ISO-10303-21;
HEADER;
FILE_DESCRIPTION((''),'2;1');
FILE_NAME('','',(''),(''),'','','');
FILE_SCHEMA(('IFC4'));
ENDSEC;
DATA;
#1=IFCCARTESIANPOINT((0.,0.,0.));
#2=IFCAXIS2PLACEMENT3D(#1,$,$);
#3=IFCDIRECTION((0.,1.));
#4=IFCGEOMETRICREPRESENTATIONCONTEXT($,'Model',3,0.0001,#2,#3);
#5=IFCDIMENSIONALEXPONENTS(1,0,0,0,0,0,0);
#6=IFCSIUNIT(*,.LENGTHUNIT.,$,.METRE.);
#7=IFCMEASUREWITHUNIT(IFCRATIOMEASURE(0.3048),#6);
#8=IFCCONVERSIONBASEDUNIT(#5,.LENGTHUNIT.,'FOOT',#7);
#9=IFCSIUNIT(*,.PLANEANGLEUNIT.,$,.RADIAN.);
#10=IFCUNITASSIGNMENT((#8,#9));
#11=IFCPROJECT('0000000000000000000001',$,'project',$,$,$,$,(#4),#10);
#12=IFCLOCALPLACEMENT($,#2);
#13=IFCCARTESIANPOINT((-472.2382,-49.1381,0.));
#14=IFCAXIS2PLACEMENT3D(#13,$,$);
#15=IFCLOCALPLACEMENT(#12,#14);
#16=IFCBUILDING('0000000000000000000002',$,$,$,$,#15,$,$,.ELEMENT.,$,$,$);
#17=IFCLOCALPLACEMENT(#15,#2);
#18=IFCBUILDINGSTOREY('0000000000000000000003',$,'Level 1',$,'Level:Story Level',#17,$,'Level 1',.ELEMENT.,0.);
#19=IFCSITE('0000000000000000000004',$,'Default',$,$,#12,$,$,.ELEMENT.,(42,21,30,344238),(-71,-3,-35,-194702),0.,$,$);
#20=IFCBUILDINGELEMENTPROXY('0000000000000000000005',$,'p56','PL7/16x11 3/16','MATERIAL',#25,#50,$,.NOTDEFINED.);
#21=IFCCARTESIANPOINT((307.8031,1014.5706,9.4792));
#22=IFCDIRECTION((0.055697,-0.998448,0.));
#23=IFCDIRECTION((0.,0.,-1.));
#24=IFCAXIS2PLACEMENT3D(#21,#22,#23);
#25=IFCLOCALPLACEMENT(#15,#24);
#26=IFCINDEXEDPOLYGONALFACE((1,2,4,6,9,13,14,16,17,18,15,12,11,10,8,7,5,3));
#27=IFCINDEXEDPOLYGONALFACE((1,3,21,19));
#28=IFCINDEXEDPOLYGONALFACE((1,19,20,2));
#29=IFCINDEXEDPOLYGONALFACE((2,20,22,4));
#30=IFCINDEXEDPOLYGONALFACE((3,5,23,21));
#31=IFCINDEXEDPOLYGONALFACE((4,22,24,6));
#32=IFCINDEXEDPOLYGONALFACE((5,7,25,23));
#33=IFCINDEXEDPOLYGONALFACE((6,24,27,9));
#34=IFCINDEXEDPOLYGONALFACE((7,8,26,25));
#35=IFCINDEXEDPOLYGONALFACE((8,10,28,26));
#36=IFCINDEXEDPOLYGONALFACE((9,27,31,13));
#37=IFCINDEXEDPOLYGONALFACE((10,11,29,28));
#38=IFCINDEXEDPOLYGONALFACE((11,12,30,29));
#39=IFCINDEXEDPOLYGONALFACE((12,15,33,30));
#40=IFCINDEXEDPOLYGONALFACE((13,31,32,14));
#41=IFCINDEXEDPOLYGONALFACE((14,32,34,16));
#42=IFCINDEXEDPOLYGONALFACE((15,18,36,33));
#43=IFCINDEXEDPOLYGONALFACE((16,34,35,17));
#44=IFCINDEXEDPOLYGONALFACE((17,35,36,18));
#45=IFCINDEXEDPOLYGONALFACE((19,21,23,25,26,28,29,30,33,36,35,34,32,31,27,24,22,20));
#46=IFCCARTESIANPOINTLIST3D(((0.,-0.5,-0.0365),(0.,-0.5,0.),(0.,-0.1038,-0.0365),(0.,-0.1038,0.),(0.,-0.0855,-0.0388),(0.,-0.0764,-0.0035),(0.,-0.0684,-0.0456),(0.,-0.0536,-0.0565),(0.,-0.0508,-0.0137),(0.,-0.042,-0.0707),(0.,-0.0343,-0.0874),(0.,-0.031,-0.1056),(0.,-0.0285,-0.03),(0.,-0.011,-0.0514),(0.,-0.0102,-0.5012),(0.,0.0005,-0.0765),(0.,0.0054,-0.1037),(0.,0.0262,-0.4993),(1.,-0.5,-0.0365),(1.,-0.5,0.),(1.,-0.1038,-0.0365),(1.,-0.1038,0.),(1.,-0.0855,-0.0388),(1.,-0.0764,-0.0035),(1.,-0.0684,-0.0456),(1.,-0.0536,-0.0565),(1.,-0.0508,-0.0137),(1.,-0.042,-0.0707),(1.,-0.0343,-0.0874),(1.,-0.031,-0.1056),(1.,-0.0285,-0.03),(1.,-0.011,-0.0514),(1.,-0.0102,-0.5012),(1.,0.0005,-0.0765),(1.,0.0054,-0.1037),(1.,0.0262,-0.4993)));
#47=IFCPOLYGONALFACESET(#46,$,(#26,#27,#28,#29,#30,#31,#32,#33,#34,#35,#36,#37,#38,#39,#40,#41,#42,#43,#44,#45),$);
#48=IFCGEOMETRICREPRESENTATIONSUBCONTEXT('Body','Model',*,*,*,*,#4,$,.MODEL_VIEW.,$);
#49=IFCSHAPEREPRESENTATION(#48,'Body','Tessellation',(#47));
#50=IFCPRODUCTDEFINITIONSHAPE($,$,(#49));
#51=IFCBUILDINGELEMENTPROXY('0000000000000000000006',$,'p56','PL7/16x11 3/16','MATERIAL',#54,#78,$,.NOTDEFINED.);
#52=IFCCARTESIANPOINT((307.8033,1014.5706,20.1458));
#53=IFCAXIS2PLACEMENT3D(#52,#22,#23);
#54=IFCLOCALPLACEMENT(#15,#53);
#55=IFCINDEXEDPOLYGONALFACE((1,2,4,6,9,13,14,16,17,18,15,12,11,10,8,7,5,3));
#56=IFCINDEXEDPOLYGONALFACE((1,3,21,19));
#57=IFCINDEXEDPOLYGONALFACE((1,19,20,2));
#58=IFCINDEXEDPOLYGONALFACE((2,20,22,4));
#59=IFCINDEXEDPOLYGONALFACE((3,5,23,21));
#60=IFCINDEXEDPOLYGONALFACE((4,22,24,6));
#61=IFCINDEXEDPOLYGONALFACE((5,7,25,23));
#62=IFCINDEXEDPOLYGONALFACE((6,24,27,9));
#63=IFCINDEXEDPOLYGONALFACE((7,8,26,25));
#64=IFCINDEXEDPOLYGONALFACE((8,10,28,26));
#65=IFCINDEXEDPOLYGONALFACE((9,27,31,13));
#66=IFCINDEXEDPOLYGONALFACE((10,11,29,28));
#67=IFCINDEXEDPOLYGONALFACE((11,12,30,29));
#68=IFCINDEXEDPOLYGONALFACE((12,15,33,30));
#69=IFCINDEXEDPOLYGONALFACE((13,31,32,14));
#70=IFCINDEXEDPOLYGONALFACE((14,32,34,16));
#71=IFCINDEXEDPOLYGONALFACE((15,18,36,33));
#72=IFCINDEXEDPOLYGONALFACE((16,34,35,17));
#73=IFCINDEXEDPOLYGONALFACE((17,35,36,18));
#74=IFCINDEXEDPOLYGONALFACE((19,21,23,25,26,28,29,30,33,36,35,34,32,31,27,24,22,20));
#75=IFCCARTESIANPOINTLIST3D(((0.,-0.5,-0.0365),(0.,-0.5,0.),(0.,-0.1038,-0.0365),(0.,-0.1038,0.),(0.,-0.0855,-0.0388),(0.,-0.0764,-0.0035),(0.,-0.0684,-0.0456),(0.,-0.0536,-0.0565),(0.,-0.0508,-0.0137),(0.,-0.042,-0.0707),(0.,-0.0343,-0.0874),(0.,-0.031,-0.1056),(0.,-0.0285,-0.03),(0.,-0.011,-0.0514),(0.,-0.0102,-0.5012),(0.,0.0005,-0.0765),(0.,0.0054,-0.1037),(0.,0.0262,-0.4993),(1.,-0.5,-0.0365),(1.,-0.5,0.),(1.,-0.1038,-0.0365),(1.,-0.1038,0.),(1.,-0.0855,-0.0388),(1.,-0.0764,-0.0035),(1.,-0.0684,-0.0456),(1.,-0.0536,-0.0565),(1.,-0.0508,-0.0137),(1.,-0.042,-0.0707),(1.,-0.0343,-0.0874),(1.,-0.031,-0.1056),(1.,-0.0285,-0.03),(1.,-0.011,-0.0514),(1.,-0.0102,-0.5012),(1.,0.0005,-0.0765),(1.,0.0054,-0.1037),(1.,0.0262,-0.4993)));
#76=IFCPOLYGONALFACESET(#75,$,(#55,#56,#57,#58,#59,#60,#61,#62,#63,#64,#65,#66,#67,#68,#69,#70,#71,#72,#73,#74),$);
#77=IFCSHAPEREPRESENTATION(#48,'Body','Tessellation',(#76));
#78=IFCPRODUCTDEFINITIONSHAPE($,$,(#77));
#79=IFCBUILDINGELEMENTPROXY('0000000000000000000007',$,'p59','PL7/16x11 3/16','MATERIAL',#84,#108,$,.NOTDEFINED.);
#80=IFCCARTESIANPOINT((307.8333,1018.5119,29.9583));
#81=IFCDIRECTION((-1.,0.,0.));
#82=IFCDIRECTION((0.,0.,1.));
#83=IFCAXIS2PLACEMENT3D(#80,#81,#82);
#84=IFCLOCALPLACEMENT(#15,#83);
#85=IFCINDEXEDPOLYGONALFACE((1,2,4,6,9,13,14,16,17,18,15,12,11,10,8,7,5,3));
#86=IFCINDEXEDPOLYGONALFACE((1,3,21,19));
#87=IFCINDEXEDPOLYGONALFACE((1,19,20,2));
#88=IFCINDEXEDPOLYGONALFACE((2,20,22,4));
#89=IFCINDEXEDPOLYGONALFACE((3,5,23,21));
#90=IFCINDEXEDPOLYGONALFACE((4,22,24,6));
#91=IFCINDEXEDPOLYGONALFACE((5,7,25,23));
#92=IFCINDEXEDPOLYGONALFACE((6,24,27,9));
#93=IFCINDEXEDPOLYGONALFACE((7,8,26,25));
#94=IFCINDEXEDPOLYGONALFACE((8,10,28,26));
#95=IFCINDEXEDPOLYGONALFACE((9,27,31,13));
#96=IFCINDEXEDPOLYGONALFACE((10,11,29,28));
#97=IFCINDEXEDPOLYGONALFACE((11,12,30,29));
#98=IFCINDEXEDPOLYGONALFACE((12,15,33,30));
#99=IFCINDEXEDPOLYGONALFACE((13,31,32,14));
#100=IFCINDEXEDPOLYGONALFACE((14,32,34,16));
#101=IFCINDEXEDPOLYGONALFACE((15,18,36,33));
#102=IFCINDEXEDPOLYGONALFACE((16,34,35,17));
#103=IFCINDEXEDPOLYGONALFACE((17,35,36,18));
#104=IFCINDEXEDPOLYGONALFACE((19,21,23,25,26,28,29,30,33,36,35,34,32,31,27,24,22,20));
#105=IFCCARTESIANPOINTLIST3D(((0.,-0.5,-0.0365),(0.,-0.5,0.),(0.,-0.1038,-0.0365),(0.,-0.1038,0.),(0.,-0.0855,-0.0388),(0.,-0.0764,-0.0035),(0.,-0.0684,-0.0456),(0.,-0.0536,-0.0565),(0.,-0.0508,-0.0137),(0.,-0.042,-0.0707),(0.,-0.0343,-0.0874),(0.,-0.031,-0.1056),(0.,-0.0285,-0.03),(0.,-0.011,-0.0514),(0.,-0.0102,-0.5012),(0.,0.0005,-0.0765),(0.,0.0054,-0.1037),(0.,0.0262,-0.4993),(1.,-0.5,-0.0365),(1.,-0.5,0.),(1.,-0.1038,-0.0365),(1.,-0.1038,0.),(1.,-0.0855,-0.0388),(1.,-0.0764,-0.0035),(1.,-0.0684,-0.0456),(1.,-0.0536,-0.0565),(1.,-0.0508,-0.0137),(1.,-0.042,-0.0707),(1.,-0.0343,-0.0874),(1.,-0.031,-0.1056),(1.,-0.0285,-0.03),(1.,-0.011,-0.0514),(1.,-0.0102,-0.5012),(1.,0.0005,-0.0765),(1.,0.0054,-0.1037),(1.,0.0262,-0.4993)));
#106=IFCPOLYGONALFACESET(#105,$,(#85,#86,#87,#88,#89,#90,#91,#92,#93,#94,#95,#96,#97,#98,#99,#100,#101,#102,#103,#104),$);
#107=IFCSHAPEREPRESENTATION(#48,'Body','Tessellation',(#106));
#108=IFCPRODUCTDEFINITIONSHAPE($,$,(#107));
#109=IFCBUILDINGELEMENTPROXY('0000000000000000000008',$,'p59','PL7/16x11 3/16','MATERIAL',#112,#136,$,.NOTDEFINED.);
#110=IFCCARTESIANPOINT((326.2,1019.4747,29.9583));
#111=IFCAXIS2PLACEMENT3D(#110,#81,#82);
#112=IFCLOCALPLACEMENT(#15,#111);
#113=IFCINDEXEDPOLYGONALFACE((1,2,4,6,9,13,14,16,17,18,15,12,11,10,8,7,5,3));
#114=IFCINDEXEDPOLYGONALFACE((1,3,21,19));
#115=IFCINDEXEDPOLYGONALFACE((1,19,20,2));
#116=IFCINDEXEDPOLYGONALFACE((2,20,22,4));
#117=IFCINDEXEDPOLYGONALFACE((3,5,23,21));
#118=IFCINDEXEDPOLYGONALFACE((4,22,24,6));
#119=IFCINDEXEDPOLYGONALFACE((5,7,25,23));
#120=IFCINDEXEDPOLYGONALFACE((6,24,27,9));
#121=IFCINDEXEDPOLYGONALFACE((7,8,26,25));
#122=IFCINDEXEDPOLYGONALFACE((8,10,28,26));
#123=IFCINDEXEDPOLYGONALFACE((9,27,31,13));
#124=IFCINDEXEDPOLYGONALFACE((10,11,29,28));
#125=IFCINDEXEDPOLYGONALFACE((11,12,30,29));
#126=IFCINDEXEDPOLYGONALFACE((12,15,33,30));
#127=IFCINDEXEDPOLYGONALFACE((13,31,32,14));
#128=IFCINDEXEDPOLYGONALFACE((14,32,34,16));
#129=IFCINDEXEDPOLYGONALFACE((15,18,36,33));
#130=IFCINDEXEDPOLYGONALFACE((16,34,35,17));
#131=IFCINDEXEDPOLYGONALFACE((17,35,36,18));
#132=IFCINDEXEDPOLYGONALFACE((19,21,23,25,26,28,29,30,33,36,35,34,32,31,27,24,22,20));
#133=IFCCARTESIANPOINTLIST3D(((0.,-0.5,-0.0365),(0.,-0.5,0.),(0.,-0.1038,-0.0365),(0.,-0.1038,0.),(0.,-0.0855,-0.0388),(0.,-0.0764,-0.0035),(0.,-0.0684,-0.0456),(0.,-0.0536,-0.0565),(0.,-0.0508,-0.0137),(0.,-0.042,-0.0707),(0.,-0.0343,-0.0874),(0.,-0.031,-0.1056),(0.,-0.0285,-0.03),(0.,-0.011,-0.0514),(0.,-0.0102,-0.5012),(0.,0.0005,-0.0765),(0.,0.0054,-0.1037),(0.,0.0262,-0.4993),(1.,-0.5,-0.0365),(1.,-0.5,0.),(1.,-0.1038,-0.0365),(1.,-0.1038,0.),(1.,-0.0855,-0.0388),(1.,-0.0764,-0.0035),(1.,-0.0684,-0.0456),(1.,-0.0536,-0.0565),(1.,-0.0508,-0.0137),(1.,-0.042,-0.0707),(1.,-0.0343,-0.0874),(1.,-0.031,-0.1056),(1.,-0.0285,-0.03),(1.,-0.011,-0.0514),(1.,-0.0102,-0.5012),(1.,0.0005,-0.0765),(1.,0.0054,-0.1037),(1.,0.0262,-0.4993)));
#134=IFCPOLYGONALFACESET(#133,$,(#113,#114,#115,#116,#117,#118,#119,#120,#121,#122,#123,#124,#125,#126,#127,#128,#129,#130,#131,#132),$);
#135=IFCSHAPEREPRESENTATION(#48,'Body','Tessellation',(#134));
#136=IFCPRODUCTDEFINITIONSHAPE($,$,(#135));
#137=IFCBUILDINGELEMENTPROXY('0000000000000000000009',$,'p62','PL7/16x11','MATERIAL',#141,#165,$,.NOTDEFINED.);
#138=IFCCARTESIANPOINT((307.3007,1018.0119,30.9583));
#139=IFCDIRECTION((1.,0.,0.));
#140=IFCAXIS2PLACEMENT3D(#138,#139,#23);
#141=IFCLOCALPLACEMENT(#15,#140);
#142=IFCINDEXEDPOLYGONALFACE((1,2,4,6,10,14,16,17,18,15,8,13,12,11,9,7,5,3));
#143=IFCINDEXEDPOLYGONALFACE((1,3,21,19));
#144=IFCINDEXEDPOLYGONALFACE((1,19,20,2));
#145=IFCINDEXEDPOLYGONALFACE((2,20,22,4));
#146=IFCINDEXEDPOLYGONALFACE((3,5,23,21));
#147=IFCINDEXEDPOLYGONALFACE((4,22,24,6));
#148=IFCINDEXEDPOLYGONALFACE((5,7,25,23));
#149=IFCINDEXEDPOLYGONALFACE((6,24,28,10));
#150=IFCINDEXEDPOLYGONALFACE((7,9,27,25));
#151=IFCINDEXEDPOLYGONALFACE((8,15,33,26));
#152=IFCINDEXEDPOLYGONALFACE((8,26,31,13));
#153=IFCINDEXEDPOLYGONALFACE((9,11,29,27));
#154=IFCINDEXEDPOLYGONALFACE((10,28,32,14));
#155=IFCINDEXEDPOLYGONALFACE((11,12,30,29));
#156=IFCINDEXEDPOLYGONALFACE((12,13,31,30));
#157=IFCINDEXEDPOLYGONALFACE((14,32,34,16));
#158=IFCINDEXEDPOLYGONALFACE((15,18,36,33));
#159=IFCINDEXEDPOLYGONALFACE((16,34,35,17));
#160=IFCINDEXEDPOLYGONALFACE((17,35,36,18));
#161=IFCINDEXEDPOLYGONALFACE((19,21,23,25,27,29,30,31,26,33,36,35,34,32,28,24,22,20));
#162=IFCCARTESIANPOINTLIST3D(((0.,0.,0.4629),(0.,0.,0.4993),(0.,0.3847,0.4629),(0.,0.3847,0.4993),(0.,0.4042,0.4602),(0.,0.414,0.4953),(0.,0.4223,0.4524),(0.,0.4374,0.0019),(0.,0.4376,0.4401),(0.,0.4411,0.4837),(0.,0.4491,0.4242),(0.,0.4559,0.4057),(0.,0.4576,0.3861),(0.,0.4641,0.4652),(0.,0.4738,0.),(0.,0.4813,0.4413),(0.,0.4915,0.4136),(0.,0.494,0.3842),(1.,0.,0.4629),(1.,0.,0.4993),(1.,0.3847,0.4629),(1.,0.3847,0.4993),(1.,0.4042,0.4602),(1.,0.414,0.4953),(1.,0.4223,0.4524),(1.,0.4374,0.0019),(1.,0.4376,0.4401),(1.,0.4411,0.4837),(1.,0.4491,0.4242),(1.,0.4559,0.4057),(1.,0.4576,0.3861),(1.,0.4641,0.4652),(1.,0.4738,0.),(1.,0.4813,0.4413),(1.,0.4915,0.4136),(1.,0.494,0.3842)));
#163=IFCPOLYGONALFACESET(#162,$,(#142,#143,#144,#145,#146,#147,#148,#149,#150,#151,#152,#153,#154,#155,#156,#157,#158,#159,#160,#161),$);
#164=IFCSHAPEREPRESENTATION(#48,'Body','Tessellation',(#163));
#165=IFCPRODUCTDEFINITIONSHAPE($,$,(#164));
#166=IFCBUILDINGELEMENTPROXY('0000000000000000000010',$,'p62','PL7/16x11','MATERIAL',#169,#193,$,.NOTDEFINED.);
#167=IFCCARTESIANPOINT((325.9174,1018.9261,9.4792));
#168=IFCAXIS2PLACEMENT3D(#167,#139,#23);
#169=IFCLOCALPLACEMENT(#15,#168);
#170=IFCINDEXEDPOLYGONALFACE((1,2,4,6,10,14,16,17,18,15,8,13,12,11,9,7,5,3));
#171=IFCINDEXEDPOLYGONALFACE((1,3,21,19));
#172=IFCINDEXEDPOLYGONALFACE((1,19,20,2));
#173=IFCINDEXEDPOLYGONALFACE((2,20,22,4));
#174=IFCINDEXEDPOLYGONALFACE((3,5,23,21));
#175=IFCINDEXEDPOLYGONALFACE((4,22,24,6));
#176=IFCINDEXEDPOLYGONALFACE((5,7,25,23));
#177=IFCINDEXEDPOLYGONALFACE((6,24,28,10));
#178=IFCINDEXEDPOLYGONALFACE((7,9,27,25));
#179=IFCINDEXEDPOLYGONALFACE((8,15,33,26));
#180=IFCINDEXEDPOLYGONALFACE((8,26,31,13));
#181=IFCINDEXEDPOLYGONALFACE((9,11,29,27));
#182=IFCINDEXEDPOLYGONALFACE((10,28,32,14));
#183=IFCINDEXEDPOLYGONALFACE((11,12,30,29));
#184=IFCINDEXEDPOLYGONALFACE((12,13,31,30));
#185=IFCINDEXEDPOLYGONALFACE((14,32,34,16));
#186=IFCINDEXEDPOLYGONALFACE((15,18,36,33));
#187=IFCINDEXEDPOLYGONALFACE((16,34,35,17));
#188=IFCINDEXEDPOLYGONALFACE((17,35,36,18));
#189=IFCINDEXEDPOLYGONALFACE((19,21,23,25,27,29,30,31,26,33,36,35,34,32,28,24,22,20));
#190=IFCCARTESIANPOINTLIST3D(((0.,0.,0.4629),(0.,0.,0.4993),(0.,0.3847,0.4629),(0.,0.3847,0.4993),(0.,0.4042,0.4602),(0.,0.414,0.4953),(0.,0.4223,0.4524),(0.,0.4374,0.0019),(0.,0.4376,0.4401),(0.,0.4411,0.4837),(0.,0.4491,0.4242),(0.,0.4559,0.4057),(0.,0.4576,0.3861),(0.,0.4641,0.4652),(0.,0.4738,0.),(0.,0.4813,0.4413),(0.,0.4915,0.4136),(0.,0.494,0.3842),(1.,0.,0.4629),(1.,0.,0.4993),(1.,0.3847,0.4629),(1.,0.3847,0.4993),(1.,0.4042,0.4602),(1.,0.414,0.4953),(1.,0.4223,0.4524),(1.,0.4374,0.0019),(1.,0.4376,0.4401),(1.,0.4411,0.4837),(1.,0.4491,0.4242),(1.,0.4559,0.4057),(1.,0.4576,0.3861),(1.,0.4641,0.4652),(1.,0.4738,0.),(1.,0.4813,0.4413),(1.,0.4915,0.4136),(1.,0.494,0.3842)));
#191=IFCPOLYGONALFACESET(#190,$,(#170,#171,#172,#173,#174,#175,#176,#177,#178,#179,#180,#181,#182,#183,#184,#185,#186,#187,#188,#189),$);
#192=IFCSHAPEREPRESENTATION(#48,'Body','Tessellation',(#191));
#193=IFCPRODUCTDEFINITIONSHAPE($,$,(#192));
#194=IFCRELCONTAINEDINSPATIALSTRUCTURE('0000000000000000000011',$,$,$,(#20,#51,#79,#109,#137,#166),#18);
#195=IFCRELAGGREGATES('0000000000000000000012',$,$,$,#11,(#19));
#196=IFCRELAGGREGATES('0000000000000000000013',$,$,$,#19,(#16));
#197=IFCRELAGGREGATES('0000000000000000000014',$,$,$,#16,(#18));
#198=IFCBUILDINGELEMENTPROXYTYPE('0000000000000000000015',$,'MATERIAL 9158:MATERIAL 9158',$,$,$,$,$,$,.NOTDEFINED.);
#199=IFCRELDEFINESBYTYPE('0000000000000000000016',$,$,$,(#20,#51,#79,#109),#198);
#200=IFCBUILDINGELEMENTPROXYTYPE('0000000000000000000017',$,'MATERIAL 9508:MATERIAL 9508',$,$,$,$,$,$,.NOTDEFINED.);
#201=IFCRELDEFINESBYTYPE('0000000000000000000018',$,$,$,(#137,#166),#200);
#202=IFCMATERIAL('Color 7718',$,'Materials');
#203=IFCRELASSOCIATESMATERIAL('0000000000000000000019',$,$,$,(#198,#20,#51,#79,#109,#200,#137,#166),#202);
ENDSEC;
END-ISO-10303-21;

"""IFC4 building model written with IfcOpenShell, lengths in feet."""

from ifc_helpers import new_model, entity, si_unit, converted_unit, direction, frame, origin, place, context, subcontext, project, spatial, polyline, outline, extrude, source, transform, mapped, material, type_object, type_shapes, element, save


model = new_model("IFC4")

# Units and contexts
model_context = context("Model", 3, precision=0.0001, world=origin(), true_north=direction((0.0, 1.0)))
body_context = subcontext(model_context, "Body", "Model", "MODEL_VIEW")
ifc_project = project(units=[converted_unit("LENGTHUNIT", "FOOT", entity("IfcRatioMeasure", 0.3048), si_unit("LENGTHUNIT", "METRE"), dimensions=[1, 0, 0, 0, 0, 0, 0]), si_unit("PLANEANGLEUNIT", "RADIAN")], contexts=[model_context])

# Site, building, storey
site_placement = place(None, origin())
site = spatial("IfcSite", under=ifc_project, at=site_placement, Name="Default", CompositionType="ELEMENT", RefLatitude=(42, 21, 30, 344238), RefLongitude=(-71, -3, -35, -194702), RefElevation=0.0)
building_placement = place(site_placement, frame((-472.2382, -49.1381, 0.0)))
building = spatial("IfcBuilding", under=site, at=building_placement, CompositionType="ELEMENT")
storey_placement = place(building_placement, origin())
storey = spatial("IfcBuildingStorey", under=building, at=storey_placement, Name="Level 1", ObjectType="Level:Story Level", LongName="Level 1", CompositionType="ELEMENT", Elevation=0.0)

# Building element proxies
ifc_material_1 = material(Name="Color 7718", Category="Materials")
building_element_proxy_type_1 = type_object("IfcBuildingElementProxyType", Name="MATERIAL 9158:MATERIAL 9158", PredefinedType="NOTDEFINED", material=ifc_material_1)
shared_shape_1 = source(origin(), body_context, "Body", "SweptSolid", [
    extrude(outline(polyline([(0.0112, -0.0976), (0.4074, -0.0976), (0.4074, -0.0611), (0.0112, -0.0611), (-0.0071, -0.0588), (-0.0242, -0.052), (-0.039, -0.0411), (-0.0507, -0.0269), (-0.0584, -0.0102), (-0.0616, 0.008), (-0.0824, 0.4036), (-0.1188, 0.4017), (-0.0981, 0.006), (-0.0931, -0.0211), (-0.0816, -0.0462), (-0.0641, -0.0676), (-0.0419, -0.0839), (-0.0162, -0.0941), (0.0112, -0.0976)])), frame((0.0, -0.0926, -0.0976), z_axis=(1.0, 0.0, 0.0), x_axis=(0.0, -1.0, 0.0)), (0.0, 0.0, 1.0), 1.0),
])
type_shapes(building_element_proxy_type_1, [shared_shape_1])
for number, where, z_axis, x_axis, name in (
    (1, (307.8031, 1014.5706, 9.4792), (0.055697, -0.998448, 0.0), (0.0, 0.0, -1.0), "p56"),
    (2, (307.8033, 1014.5706, 20.1458), (0.055697, -0.998448, 0.0), (0.0, 0.0, -1.0), "p56"),
    (3, (307.8333, 1018.5119, 29.9583), (-1.0, 0.0, 0.0), (0.0, 0.0, 1.0), "p59"),
    (4, (326.2, 1019.4747, 29.9583), (-1.0, 0.0, 0.0), (0.0, 0.0, 1.0), "p59"),
):
    element("IfcBuildingElementProxy", number, at=place(building_placement, frame(where, z_axis=z_axis, x_axis=x_axis)), inside=storey, type_object=building_element_proxy_type_1, material=ifc_material_1, Name=name, Description="PL7/16x11 3/16", ObjectType="MATERIAL", PredefinedType="NOTDEFINED", context=body_context, shape_type="MappedRepresentation", body=[
        mapped(shared_shape_1, transform((0.0, 0.0, 0.0), scale=1.0)),
    ])
building_element_proxy_type_2 = type_object("IfcBuildingElementProxyType", Name="MATERIAL 9508:MATERIAL 9508", PredefinedType="NOTDEFINED", material=ifc_material_1)
shared_shape_2 = source(origin(), body_context, "Body", "SweptSolid", [
    extrude(outline(polyline([(0.0093, -0.1005), (0.3941, -0.1005), (0.3941, -0.0641), (0.0093, -0.0641), (-0.0101, -0.0614), (-0.0282, -0.0536), (-0.0436, -0.0413), (-0.055, -0.0254), (-0.0619, -0.0069), (-0.0635, 0.0127), (-0.0433, 0.3969), (-0.0798, 0.3988), (-0.0999, 0.0146), (-0.0974, -0.0148), (-0.0872, -0.0425), (-0.07, -0.0664), (-0.047, -0.0849), (-0.0199, -0.0965), (0.0093, -0.1005)])), frame((0.0, 0.3941, 0.3988), z_axis=(1.0, 0.0, 0.0), x_axis=(0.0, -1.0, 0.0)), (0.0, 0.0, 1.0), 1.0),
])
type_shapes(building_element_proxy_type_2, [shared_shape_2])
for number, where, z_axis, x_axis, name in (
    (5, (307.3007, 1018.0119, 30.9583), (1.0, 0.0, 0.0), (0.0, 0.0, -1.0), "p62"),
    (6, (325.9174, 1018.9261, 9.4792), (1.0, 0.0, 0.0), (0.0, 0.0, -1.0), "p62"),
):
    element("IfcBuildingElementProxy", number, at=place(building_placement, frame(where, z_axis=z_axis, x_axis=x_axis)), inside=storey, type_object=building_element_proxy_type_2, material=ifc_material_1, Name=name, Description="PL7/16x11", ObjectType="MATERIAL", PredefinedType="NOTDEFINED", context=body_context, shape_type="MappedRepresentation", body=[
        mapped(shared_shape_2, transform((0.0, 0.0, 0.0), scale=1.0)),
    ])

save(model, "model.ifc")
